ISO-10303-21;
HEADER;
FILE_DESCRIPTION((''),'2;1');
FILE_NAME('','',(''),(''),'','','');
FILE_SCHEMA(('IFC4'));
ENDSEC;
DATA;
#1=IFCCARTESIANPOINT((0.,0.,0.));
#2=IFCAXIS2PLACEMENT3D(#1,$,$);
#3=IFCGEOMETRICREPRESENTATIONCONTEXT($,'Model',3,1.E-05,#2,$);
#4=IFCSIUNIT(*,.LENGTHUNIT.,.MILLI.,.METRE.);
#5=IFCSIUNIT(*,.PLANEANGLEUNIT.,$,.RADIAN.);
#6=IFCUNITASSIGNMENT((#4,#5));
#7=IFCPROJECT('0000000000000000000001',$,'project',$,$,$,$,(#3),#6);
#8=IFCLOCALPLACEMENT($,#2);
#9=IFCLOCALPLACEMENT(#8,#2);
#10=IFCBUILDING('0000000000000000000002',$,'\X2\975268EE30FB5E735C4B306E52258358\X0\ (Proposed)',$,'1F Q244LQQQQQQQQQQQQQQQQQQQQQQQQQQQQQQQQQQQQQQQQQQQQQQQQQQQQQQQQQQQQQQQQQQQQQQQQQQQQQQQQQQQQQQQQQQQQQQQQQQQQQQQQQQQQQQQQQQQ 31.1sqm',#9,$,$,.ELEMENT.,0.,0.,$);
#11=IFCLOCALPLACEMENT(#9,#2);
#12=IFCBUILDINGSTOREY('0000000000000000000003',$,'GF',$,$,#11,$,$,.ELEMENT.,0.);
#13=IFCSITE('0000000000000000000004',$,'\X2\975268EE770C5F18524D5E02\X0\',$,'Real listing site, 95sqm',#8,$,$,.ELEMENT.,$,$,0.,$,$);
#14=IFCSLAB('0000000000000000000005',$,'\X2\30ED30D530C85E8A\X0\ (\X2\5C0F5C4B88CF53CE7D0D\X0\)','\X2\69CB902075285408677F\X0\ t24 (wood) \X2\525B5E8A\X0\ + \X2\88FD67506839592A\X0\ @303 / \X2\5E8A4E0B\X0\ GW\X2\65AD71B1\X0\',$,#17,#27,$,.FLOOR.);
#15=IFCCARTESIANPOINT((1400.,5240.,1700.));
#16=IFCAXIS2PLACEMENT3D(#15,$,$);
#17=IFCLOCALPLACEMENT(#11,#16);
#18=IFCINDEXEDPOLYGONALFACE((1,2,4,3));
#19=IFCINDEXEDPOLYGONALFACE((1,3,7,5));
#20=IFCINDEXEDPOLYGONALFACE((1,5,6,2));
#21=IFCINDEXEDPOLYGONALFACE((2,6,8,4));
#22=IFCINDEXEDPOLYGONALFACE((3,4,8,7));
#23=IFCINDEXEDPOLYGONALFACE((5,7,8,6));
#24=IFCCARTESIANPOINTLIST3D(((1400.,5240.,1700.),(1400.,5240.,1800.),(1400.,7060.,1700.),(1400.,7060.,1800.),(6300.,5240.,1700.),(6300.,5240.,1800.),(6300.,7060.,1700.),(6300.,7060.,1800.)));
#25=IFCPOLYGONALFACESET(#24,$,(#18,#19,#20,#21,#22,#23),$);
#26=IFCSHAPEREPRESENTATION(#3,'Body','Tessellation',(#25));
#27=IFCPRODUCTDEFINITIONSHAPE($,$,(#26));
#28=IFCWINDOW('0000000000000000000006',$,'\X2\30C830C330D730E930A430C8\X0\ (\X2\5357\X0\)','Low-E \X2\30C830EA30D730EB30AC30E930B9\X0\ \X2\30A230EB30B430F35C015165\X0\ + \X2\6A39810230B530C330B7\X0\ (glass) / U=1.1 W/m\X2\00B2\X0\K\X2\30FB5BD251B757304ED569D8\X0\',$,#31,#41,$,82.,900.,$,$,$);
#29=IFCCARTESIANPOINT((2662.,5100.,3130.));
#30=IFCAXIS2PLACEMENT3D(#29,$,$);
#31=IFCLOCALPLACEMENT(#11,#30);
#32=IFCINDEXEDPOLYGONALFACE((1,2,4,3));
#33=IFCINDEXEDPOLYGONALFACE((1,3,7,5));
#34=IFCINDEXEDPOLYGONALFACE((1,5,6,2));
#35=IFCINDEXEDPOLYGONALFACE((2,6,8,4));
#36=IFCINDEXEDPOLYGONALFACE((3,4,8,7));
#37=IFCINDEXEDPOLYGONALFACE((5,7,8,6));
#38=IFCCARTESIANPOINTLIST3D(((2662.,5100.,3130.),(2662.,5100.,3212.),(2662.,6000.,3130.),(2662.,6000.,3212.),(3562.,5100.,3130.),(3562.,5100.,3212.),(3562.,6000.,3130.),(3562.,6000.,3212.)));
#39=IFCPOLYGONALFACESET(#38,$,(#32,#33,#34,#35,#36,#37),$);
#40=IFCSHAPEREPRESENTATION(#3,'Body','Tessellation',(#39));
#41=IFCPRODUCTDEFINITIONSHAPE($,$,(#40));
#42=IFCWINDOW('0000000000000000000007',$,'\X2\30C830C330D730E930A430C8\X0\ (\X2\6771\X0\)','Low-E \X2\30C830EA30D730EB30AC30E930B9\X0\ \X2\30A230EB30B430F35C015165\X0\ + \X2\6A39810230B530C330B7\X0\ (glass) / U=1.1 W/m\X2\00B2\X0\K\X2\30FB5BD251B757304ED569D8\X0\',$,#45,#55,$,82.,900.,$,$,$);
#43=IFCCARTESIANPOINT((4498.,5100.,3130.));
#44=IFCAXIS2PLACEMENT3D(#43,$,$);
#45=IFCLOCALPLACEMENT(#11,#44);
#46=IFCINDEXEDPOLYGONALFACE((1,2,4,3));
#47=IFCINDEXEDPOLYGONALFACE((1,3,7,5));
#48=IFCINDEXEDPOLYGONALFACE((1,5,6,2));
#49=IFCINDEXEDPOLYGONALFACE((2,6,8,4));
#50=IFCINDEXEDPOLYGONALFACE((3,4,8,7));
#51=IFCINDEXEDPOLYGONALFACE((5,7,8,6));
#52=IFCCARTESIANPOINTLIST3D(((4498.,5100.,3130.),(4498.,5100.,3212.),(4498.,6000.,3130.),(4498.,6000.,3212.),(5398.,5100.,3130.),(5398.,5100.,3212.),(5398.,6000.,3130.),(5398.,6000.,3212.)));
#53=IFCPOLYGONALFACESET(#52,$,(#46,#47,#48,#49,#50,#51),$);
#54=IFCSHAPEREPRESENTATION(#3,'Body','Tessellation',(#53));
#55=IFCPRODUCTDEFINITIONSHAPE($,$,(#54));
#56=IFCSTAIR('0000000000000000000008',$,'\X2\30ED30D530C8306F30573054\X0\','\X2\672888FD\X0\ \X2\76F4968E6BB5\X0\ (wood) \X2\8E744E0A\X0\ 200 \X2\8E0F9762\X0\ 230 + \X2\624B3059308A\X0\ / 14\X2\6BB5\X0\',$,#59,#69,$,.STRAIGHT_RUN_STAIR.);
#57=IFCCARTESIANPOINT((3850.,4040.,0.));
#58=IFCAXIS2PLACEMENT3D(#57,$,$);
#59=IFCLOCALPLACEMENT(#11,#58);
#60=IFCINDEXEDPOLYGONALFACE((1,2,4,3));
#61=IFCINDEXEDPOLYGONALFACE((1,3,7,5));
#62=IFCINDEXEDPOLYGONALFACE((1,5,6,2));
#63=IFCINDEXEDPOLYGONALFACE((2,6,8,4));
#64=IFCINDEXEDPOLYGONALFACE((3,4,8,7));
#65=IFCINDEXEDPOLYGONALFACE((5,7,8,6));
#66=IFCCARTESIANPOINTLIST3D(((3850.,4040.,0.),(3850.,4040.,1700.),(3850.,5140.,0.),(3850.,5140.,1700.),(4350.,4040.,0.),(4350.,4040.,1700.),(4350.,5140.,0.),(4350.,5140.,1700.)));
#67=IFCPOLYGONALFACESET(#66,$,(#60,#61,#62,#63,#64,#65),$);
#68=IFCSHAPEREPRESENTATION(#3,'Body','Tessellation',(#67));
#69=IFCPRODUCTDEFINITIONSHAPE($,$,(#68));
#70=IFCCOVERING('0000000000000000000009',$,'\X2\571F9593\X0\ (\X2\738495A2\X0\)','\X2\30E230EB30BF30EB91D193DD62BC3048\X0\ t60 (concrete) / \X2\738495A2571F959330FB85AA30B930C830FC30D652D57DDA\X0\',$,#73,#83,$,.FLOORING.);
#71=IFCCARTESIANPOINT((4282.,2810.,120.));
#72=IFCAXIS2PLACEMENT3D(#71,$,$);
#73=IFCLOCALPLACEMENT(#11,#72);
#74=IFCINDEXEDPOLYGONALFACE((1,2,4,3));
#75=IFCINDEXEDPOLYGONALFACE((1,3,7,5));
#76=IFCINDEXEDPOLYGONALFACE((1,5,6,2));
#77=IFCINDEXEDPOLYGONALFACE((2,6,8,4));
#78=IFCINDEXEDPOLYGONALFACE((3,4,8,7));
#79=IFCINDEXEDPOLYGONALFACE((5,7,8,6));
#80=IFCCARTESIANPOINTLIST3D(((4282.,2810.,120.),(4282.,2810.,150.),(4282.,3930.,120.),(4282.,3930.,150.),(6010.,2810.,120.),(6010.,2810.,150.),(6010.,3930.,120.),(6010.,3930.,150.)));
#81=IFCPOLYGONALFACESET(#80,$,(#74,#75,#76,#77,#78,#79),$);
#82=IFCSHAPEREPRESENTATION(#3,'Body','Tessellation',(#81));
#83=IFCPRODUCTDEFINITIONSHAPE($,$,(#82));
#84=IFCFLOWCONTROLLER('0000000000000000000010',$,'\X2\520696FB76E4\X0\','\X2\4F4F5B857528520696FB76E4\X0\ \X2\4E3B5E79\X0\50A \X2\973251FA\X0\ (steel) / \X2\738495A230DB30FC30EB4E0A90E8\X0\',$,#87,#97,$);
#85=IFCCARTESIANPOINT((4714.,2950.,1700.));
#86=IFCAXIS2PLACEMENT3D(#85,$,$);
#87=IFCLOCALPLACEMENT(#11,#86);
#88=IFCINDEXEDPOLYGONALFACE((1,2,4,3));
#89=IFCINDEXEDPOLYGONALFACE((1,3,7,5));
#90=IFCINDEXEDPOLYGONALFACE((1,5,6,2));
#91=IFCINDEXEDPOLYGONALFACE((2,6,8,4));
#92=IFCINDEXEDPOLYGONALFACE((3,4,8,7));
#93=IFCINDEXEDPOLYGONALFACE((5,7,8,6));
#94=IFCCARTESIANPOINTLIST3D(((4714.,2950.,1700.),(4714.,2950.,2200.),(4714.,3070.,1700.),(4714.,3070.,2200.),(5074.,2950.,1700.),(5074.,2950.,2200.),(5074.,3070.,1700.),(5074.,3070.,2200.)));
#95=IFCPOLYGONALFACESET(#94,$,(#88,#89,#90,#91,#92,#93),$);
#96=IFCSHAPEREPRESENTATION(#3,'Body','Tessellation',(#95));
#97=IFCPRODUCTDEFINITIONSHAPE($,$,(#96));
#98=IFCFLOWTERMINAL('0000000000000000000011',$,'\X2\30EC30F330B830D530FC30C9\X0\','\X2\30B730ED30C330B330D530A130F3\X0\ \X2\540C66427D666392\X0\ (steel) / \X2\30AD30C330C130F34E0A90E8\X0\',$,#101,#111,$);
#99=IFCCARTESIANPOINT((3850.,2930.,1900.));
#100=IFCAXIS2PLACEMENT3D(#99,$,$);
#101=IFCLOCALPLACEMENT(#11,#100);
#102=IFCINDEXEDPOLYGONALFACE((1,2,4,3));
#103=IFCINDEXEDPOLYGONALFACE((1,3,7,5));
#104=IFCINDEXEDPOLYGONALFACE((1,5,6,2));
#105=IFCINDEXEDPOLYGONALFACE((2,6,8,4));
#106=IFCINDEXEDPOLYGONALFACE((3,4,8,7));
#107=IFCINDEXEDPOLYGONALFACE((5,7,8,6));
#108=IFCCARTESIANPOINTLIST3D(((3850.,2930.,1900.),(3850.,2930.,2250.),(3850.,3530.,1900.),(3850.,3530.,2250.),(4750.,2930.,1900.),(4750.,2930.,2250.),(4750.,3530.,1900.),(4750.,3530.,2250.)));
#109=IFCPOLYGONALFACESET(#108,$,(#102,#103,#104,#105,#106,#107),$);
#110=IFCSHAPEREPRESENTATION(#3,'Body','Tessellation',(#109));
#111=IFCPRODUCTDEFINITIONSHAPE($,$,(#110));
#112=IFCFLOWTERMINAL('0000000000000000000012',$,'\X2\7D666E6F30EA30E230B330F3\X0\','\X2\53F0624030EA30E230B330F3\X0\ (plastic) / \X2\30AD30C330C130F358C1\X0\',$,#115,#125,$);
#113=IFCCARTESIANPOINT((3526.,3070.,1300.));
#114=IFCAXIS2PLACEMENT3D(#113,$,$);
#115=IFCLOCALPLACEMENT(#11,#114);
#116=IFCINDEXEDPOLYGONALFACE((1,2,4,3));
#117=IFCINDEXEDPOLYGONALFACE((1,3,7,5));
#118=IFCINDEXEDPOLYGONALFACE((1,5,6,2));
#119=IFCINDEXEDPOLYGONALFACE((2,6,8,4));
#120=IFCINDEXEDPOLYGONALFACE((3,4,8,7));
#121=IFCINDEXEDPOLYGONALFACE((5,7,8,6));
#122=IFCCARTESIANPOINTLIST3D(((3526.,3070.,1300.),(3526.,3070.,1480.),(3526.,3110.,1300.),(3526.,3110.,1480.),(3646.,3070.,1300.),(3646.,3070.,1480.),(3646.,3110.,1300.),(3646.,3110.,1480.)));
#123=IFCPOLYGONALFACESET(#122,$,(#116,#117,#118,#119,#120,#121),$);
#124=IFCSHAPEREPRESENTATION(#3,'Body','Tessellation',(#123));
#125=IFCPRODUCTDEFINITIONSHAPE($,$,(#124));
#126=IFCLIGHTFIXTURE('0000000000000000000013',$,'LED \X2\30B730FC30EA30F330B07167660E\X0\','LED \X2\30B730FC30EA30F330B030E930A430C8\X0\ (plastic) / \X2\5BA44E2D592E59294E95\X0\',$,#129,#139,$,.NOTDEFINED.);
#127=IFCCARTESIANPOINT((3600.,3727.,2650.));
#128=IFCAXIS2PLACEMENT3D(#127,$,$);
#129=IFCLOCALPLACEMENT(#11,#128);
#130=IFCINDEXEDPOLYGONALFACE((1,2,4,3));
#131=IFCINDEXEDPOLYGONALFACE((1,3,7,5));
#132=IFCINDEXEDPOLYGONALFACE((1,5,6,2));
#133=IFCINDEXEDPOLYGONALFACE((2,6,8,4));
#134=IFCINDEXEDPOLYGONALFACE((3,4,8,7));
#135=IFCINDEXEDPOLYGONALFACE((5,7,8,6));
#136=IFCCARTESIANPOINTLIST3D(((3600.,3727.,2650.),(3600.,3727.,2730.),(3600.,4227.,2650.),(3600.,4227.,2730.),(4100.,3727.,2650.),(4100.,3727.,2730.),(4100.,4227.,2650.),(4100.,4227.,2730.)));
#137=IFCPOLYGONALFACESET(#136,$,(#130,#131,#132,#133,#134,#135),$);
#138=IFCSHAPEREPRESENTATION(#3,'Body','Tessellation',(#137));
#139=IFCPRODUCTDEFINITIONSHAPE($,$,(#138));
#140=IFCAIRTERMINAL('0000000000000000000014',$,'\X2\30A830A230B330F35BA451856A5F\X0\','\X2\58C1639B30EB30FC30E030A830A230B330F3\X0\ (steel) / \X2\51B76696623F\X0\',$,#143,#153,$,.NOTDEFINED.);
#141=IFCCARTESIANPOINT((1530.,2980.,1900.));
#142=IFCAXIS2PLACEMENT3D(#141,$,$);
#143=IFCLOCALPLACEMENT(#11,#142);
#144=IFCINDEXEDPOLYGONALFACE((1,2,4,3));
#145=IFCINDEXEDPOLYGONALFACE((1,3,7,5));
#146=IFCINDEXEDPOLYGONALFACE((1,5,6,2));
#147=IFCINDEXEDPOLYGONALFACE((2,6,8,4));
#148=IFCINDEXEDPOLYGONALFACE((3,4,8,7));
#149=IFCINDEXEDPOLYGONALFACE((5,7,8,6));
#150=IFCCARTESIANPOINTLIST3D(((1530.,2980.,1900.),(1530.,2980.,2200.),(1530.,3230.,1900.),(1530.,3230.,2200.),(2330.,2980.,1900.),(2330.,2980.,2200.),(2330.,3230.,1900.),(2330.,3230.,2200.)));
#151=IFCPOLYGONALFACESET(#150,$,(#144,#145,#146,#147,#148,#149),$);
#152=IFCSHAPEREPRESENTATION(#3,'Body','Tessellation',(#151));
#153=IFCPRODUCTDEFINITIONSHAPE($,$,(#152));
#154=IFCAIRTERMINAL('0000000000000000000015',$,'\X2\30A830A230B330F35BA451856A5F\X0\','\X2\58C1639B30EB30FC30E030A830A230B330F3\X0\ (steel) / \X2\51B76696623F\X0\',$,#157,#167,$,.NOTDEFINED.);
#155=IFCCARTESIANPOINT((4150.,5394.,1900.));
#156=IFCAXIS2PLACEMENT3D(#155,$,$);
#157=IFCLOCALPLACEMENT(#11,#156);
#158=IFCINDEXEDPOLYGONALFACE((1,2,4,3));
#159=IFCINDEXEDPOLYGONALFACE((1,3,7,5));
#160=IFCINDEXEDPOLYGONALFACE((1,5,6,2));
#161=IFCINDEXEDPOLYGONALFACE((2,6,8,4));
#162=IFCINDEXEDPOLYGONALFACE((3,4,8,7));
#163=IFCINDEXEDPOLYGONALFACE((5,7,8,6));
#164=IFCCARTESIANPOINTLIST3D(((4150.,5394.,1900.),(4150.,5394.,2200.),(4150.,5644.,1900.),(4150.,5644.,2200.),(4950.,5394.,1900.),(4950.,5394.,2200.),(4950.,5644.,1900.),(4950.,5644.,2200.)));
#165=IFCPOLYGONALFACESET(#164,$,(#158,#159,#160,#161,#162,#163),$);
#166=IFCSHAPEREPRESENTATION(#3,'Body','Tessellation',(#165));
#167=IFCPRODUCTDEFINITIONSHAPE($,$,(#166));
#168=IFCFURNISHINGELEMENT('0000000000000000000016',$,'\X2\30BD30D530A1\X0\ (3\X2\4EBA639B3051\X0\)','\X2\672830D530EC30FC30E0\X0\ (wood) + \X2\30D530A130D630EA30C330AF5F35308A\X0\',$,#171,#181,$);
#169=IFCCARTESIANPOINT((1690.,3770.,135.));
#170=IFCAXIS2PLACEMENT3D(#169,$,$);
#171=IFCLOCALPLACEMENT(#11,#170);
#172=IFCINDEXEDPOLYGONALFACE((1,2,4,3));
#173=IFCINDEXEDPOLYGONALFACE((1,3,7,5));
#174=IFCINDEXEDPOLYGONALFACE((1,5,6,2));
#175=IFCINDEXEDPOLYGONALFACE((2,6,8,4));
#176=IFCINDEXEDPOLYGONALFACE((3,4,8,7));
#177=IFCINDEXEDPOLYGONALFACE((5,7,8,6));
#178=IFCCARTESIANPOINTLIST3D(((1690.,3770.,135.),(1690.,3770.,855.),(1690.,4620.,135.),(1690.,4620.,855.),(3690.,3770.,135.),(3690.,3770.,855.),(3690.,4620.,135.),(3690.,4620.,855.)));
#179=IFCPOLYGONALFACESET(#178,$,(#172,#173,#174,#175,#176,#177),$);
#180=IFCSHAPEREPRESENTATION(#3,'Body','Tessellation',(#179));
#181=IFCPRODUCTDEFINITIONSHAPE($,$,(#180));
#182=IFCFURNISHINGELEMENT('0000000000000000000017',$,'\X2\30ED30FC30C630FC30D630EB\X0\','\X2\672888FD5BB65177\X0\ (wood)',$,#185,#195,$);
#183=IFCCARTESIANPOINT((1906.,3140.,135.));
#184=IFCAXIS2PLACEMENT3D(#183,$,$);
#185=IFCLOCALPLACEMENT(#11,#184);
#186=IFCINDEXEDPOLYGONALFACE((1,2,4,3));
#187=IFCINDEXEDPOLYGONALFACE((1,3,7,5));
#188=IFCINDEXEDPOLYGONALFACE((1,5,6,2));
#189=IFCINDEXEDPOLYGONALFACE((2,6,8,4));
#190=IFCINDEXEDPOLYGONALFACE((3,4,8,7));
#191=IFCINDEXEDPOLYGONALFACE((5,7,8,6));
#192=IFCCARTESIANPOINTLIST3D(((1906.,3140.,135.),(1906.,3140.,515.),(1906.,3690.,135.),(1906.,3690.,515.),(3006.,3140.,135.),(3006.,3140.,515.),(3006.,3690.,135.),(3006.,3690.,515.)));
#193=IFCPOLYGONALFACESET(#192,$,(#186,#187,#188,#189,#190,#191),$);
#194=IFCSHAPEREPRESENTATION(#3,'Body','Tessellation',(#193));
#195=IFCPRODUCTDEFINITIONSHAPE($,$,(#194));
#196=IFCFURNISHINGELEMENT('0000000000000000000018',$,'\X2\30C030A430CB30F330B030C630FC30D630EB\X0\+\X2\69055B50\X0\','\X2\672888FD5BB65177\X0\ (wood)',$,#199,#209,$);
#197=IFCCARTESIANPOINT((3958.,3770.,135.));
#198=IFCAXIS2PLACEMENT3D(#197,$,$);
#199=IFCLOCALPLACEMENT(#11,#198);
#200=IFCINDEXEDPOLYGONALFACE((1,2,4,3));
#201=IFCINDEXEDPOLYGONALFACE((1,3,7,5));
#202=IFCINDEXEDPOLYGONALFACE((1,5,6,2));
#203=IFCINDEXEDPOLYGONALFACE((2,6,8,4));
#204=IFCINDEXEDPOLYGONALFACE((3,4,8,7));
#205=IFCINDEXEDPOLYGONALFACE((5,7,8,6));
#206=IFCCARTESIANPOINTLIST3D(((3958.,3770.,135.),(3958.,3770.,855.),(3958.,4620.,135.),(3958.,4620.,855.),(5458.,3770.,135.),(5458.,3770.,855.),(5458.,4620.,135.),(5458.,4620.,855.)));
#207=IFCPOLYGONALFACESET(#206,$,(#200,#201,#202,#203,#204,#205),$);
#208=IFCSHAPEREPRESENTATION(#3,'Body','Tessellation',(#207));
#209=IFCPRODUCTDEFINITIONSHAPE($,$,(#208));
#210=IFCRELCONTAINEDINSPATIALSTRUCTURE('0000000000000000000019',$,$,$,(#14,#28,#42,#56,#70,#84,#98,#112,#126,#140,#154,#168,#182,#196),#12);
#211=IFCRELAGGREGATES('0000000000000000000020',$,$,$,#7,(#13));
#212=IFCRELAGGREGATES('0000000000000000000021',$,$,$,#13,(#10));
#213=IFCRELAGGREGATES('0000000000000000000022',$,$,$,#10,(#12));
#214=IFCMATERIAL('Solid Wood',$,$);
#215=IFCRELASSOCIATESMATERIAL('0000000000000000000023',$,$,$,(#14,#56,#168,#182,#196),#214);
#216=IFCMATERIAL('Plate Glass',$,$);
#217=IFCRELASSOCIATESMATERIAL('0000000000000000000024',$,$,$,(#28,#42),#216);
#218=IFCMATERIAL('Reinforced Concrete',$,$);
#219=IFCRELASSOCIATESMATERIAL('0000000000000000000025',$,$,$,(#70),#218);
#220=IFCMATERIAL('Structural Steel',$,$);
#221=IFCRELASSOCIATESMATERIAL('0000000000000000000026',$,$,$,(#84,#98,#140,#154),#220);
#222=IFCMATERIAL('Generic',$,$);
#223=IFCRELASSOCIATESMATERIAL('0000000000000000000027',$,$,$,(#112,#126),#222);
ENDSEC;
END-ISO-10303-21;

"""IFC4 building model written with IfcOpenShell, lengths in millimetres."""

from ifc_helpers import new_model, si_unit, frame, frame_2d, origin, place, context, project, spatial, rectangle, extrude, material, element, save


model = new_model("IFC4")

# Units and contexts
model_context = context("Model", 3, precision=1e-05, world=origin())
ifc_project = project(units=[si_unit("LENGTHUNIT", "METRE", prefix="MILLI"), si_unit("PLANEANGLEUNIT", "RADIAN")], contexts=[model_context])

# Site, building, storey
site_placement = place(None, origin())
site = spatial("IfcSite", under=ifc_project, at=site_placement, Name="青森県弘前市", ObjectType="Real listing site, 95sqm", CompositionType="ELEMENT", RefElevation=0.0)
building_placement = place(site_placement, origin())
building = spatial("IfcBuilding", under=site, at=building_placement, Name="青森・平屋の別荘 (Proposed)", ObjectType="1F Q244LQQQQQQQQQQQQQQQQQQQQQQQQQQQQQQQQQQQQQQQQQQQQQQQQQQQQQQQQQQQQQQQQQQQQQQQQQQQQQQQQQQQQQQQQQQQQQQQQQQQQQQQQQQQQQQQQQQQ 31.1sqm", CompositionType="ELEMENT", ElevationOfRefHeight=0.0, ElevationOfTerrain=0.0)
storey_placement = place(building_placement, origin())
storey = spatial("IfcBuildingStorey", under=building, at=storey_placement, Name="GF", CompositionType="ELEMENT", Elevation=0.0)

# Shared definitions
ifc_material_1 = material(Name="Solid Wood")

# Slab
slab_placement = place(storey_placement, frame((1400.0, 5240.0, 1700.0)))
element("IfcSlab", 1, at=slab_placement, inside=storey, material=ifc_material_1, Name="ロフト床 (小屋裏収納)", Description="構造用合板 t24 (wood) 剛床 + 製材根太 @303 / 床下 GW断熱", PredefinedType="FLOOR", context=model_context, shape_type="SweptSolid", body=[
    extrude(rectangle(XDim=4900.0, YDim=1820.0, at=frame_2d((2450.0, 910.0))), frame((1400.0, 5240.0, 1700.0)), (0.0, 0.0, 1.0), 100.0),
])

# Windows
ifc_material_2 = material(Name="Plate Glass")
window_1_placement = place(storey_placement, frame((2662.0, 5100.0, 3130.0)))
element("IfcWindow", 2, at=window_1_placement, inside=storey, material=ifc_material_2, Name="トップライト (南)", Description="Low-E トリプルガラス アルゴン封入 + 樹脂サッシ (glass) / U=1.1 W/m²K・寒冷地仕様", OverallHeight=82.0, OverallWidth=900.0, context=model_context, shape_type="SweptSolid", body=[
    extrude(rectangle(XDim=900.0, YDim=900.0, at=frame_2d((450.0, 450.0))), frame((2662.0, 5100.0, 3130.0)), (0.0, 0.0, 1.0), 82.0),
])
window_2_placement = place(storey_placement, frame((4498.0, 5100.0, 3130.0)))
element("IfcWindow", 3, at=window_2_placement, inside=storey, material=ifc_material_2, Name="トップライト (東)", Description="Low-E トリプルガラス アルゴン封入 + 樹脂サッシ (glass) / U=1.1 W/m²K・寒冷地仕様", OverallHeight=82.0, OverallWidth=900.0, context=model_context, shape_type="SweptSolid", body=[
    extrude(rectangle(XDim=900.0, YDim=900.0, at=frame_2d((450.0, 450.0))), frame((4498.0, 5100.0, 3130.0)), (0.0, 0.0, 1.0), 82.0),
])

# Stair
stair_placement = place(storey_placement, frame((3850.0, 4040.0, 0.0)))
element("IfcStair", 4, at=stair_placement, inside=storey, material=ifc_material_1, Name="ロフトはしご", Description="木製 直階段 (wood) 蹴上 200 踏面 230 + 手すり / 14段", PredefinedType="STRAIGHT_RUN_STAIR", context=model_context, shape_type="SweptSolid", body=[
    extrude(rectangle(XDim=500.0, YDim=1100.0, at=frame_2d((250.0, 550.0))), frame((3850.0, 4040.0, 0.0)), (0.0, 0.0, 1.0), 1700.0),
])

# Covering
ifc_material_3 = material(Name="Reinforced Concrete")
covering_placement = place(storey_placement, frame((4282.0, 2810.0, 120.0)))
element("IfcCovering", 5, at=covering_placement, inside=storey, material=ifc_material_3, Name="土間 (玄関)", Description="モルタル金鏝押え t60 (concrete) / 玄関土間・薪ストーブ動線", PredefinedType="FLOORING", context=model_context, shape_type="SweptSolid", body=[
    extrude(rectangle(XDim=1728.0, YDim=1120.0, at=frame_2d((864.0, 560.0))), frame((4282.0, 2810.0, 120.0)), (0.0, 0.0, 1.0), 30.0),
])

# Flow controller
ifc_material_4 = material(Name="Structural Steel")
flow_controller_placement = place(storey_placement, frame((4714.0, 2950.0, 1700.0)))
element("IfcFlowController", 6, at=flow_controller_placement, inside=storey, material=ifc_material_4, Name="分電盤", Description="住宅用分電盤 主幹50A 露出 (steel) / 玄関ホール上部", context=model_context, shape_type="SweptSolid", body=[
    extrude(rectangle(XDim=360.0, YDim=120.0, at=frame_2d((180.0, 60.0))), frame((4714.0, 2950.0, 1700.0)), (0.0, 0.0, 1.0), 500.0),
])

# Flow terminals
flow_terminal_1_placement = place(storey_placement, frame((3850.0, 2930.0, 1900.0)))
element("IfcFlowTerminal", 7, at=flow_terminal_1_placement, inside=storey, material=ifc_material_4, Name="レンジフード", Description="シロッコファン 同時給排 (steel) / キッチン上部", context=model_context, shape_type="SweptSolid", body=[
    extrude(rectangle(XDim=900.0, YDim=600.0, at=frame_2d((450.0, 300.0))), frame((3850.0, 2930.0, 1900.0)), (0.0, 0.0, 1.0), 350.0),
])
ifc_material_5 = material(Name="Generic")
flow_terminal_2_placement = place(storey_placement, frame((3526.0, 3070.0, 1300.0)))
element("IfcFlowTerminal", 8, at=flow_terminal_2_placement, inside=storey, material=ifc_material_5, Name="給湯リモコン", Description="台所リモコン (plastic) / キッチン壁", context=model_context, shape_type="SweptSolid", body=[
    extrude(rectangle(XDim=120.0, YDim=40.0, at=frame_2d((60.0, 20.0))), frame((3526.0, 3070.0, 1300.0)), (0.0, 0.0, 1.0), 180.0),
])

# Light fixture
light_fixture_placement = place(storey_placement, frame((3600.0, 3727.0, 2650.0)))
element("IfcLightFixture", 9, at=light_fixture_placement, inside=storey, material=ifc_material_5, Name="LED シーリング照明", Description="LED シーリングライト (plastic) / 室中央天井", PredefinedType="NOTDEFINED", context=model_context, shape_type="SweptSolid", body=[
    extrude(rectangle(XDim=500.0, YDim=500.0, at=frame_2d((250.0, 250.0))), frame((3600.0, 3727.0, 2650.0)), (0.0, 0.0, 1.0), 80.0),
])

# Air terminals
air_terminal_1_placement = place(storey_placement, frame((1530.0, 2980.0, 1900.0)))
element("IfcAirTerminal", 10, at=air_terminal_1_placement, inside=storey, material=ifc_material_4, Name="エアコン室内機", Description="壁掛ルームエアコン (steel) / 冷暖房", PredefinedType="NOTDEFINED", context=model_context, shape_type="SweptSolid", body=[
    extrude(rectangle(XDim=800.0, YDim=250.0, at=frame_2d((400.0, 125.0))), frame((1530.0, 2980.0, 1900.0)), (0.0, 0.0, 1.0), 300.0),
])
air_terminal_2_placement = place(storey_placement, frame((4150.0, 5394.0, 1900.0)))
element("IfcAirTerminal", 11, at=air_terminal_2_placement, inside=storey, material=ifc_material_4, Name="エアコン室内機", Description="壁掛ルームエアコン (steel) / 冷暖房", PredefinedType="NOTDEFINED", context=model_context, shape_type="SweptSolid", body=[
    extrude(rectangle(XDim=800.0, YDim=250.0, at=frame_2d((400.0, 125.0))), frame((4150.0, 5394.0, 1900.0)), (0.0, 0.0, 1.0), 300.0),
])

# Furnishing elements
furnishing_1_placement = place(storey_placement, frame((1690.0, 3770.0, 135.0)))
element("IfcFurnishingElement", 12, at=furnishing_1_placement, inside=storey, material=ifc_material_1, Name="ソファ (3人掛け)", Description="木フレーム (wood) + ファブリック張り", context=model_context, shape_type="SweptSolid", body=[
    extrude(rectangle(XDim=2000.0, YDim=850.0, at=frame_2d((1000.0, 425.0))), frame((1690.0, 3770.0, 135.0)), (0.0, 0.0, 1.0), 720.0),
])
furnishing_2_placement = place(storey_placement, frame((1906.0, 3140.0, 135.0)))
element("IfcFurnishingElement", 13, at=furnishing_2_placement, inside=storey, material=ifc_material_1, Name="ローテーブル", Description="木製家具 (wood)", context=model_context, shape_type="SweptSolid", body=[
    extrude(rectangle(XDim=1100.0, YDim=550.0, at=frame_2d((550.0, 275.0))), frame((1906.0, 3140.0, 135.0)), (0.0, 0.0, 1.0), 380.0),
])
furnishing_3_placement = place(storey_placement, frame((3958.0, 3770.0, 135.0)))
element("IfcFurnishingElement", 14, at=furnishing_3_placement, inside=storey, material=ifc_material_1, Name="ダイニングテーブル+椅子", Description="木製家具 (wood)", context=model_context, shape_type="SweptSolid", body=[
    extrude(rectangle(XDim=1500.0, YDim=850.0, at=frame_2d((750.0, 425.0))), frame((3958.0, 3770.0, 135.0)), (0.0, 0.0, 1.0), 720.0),
])

save(model, "model.ifc")
